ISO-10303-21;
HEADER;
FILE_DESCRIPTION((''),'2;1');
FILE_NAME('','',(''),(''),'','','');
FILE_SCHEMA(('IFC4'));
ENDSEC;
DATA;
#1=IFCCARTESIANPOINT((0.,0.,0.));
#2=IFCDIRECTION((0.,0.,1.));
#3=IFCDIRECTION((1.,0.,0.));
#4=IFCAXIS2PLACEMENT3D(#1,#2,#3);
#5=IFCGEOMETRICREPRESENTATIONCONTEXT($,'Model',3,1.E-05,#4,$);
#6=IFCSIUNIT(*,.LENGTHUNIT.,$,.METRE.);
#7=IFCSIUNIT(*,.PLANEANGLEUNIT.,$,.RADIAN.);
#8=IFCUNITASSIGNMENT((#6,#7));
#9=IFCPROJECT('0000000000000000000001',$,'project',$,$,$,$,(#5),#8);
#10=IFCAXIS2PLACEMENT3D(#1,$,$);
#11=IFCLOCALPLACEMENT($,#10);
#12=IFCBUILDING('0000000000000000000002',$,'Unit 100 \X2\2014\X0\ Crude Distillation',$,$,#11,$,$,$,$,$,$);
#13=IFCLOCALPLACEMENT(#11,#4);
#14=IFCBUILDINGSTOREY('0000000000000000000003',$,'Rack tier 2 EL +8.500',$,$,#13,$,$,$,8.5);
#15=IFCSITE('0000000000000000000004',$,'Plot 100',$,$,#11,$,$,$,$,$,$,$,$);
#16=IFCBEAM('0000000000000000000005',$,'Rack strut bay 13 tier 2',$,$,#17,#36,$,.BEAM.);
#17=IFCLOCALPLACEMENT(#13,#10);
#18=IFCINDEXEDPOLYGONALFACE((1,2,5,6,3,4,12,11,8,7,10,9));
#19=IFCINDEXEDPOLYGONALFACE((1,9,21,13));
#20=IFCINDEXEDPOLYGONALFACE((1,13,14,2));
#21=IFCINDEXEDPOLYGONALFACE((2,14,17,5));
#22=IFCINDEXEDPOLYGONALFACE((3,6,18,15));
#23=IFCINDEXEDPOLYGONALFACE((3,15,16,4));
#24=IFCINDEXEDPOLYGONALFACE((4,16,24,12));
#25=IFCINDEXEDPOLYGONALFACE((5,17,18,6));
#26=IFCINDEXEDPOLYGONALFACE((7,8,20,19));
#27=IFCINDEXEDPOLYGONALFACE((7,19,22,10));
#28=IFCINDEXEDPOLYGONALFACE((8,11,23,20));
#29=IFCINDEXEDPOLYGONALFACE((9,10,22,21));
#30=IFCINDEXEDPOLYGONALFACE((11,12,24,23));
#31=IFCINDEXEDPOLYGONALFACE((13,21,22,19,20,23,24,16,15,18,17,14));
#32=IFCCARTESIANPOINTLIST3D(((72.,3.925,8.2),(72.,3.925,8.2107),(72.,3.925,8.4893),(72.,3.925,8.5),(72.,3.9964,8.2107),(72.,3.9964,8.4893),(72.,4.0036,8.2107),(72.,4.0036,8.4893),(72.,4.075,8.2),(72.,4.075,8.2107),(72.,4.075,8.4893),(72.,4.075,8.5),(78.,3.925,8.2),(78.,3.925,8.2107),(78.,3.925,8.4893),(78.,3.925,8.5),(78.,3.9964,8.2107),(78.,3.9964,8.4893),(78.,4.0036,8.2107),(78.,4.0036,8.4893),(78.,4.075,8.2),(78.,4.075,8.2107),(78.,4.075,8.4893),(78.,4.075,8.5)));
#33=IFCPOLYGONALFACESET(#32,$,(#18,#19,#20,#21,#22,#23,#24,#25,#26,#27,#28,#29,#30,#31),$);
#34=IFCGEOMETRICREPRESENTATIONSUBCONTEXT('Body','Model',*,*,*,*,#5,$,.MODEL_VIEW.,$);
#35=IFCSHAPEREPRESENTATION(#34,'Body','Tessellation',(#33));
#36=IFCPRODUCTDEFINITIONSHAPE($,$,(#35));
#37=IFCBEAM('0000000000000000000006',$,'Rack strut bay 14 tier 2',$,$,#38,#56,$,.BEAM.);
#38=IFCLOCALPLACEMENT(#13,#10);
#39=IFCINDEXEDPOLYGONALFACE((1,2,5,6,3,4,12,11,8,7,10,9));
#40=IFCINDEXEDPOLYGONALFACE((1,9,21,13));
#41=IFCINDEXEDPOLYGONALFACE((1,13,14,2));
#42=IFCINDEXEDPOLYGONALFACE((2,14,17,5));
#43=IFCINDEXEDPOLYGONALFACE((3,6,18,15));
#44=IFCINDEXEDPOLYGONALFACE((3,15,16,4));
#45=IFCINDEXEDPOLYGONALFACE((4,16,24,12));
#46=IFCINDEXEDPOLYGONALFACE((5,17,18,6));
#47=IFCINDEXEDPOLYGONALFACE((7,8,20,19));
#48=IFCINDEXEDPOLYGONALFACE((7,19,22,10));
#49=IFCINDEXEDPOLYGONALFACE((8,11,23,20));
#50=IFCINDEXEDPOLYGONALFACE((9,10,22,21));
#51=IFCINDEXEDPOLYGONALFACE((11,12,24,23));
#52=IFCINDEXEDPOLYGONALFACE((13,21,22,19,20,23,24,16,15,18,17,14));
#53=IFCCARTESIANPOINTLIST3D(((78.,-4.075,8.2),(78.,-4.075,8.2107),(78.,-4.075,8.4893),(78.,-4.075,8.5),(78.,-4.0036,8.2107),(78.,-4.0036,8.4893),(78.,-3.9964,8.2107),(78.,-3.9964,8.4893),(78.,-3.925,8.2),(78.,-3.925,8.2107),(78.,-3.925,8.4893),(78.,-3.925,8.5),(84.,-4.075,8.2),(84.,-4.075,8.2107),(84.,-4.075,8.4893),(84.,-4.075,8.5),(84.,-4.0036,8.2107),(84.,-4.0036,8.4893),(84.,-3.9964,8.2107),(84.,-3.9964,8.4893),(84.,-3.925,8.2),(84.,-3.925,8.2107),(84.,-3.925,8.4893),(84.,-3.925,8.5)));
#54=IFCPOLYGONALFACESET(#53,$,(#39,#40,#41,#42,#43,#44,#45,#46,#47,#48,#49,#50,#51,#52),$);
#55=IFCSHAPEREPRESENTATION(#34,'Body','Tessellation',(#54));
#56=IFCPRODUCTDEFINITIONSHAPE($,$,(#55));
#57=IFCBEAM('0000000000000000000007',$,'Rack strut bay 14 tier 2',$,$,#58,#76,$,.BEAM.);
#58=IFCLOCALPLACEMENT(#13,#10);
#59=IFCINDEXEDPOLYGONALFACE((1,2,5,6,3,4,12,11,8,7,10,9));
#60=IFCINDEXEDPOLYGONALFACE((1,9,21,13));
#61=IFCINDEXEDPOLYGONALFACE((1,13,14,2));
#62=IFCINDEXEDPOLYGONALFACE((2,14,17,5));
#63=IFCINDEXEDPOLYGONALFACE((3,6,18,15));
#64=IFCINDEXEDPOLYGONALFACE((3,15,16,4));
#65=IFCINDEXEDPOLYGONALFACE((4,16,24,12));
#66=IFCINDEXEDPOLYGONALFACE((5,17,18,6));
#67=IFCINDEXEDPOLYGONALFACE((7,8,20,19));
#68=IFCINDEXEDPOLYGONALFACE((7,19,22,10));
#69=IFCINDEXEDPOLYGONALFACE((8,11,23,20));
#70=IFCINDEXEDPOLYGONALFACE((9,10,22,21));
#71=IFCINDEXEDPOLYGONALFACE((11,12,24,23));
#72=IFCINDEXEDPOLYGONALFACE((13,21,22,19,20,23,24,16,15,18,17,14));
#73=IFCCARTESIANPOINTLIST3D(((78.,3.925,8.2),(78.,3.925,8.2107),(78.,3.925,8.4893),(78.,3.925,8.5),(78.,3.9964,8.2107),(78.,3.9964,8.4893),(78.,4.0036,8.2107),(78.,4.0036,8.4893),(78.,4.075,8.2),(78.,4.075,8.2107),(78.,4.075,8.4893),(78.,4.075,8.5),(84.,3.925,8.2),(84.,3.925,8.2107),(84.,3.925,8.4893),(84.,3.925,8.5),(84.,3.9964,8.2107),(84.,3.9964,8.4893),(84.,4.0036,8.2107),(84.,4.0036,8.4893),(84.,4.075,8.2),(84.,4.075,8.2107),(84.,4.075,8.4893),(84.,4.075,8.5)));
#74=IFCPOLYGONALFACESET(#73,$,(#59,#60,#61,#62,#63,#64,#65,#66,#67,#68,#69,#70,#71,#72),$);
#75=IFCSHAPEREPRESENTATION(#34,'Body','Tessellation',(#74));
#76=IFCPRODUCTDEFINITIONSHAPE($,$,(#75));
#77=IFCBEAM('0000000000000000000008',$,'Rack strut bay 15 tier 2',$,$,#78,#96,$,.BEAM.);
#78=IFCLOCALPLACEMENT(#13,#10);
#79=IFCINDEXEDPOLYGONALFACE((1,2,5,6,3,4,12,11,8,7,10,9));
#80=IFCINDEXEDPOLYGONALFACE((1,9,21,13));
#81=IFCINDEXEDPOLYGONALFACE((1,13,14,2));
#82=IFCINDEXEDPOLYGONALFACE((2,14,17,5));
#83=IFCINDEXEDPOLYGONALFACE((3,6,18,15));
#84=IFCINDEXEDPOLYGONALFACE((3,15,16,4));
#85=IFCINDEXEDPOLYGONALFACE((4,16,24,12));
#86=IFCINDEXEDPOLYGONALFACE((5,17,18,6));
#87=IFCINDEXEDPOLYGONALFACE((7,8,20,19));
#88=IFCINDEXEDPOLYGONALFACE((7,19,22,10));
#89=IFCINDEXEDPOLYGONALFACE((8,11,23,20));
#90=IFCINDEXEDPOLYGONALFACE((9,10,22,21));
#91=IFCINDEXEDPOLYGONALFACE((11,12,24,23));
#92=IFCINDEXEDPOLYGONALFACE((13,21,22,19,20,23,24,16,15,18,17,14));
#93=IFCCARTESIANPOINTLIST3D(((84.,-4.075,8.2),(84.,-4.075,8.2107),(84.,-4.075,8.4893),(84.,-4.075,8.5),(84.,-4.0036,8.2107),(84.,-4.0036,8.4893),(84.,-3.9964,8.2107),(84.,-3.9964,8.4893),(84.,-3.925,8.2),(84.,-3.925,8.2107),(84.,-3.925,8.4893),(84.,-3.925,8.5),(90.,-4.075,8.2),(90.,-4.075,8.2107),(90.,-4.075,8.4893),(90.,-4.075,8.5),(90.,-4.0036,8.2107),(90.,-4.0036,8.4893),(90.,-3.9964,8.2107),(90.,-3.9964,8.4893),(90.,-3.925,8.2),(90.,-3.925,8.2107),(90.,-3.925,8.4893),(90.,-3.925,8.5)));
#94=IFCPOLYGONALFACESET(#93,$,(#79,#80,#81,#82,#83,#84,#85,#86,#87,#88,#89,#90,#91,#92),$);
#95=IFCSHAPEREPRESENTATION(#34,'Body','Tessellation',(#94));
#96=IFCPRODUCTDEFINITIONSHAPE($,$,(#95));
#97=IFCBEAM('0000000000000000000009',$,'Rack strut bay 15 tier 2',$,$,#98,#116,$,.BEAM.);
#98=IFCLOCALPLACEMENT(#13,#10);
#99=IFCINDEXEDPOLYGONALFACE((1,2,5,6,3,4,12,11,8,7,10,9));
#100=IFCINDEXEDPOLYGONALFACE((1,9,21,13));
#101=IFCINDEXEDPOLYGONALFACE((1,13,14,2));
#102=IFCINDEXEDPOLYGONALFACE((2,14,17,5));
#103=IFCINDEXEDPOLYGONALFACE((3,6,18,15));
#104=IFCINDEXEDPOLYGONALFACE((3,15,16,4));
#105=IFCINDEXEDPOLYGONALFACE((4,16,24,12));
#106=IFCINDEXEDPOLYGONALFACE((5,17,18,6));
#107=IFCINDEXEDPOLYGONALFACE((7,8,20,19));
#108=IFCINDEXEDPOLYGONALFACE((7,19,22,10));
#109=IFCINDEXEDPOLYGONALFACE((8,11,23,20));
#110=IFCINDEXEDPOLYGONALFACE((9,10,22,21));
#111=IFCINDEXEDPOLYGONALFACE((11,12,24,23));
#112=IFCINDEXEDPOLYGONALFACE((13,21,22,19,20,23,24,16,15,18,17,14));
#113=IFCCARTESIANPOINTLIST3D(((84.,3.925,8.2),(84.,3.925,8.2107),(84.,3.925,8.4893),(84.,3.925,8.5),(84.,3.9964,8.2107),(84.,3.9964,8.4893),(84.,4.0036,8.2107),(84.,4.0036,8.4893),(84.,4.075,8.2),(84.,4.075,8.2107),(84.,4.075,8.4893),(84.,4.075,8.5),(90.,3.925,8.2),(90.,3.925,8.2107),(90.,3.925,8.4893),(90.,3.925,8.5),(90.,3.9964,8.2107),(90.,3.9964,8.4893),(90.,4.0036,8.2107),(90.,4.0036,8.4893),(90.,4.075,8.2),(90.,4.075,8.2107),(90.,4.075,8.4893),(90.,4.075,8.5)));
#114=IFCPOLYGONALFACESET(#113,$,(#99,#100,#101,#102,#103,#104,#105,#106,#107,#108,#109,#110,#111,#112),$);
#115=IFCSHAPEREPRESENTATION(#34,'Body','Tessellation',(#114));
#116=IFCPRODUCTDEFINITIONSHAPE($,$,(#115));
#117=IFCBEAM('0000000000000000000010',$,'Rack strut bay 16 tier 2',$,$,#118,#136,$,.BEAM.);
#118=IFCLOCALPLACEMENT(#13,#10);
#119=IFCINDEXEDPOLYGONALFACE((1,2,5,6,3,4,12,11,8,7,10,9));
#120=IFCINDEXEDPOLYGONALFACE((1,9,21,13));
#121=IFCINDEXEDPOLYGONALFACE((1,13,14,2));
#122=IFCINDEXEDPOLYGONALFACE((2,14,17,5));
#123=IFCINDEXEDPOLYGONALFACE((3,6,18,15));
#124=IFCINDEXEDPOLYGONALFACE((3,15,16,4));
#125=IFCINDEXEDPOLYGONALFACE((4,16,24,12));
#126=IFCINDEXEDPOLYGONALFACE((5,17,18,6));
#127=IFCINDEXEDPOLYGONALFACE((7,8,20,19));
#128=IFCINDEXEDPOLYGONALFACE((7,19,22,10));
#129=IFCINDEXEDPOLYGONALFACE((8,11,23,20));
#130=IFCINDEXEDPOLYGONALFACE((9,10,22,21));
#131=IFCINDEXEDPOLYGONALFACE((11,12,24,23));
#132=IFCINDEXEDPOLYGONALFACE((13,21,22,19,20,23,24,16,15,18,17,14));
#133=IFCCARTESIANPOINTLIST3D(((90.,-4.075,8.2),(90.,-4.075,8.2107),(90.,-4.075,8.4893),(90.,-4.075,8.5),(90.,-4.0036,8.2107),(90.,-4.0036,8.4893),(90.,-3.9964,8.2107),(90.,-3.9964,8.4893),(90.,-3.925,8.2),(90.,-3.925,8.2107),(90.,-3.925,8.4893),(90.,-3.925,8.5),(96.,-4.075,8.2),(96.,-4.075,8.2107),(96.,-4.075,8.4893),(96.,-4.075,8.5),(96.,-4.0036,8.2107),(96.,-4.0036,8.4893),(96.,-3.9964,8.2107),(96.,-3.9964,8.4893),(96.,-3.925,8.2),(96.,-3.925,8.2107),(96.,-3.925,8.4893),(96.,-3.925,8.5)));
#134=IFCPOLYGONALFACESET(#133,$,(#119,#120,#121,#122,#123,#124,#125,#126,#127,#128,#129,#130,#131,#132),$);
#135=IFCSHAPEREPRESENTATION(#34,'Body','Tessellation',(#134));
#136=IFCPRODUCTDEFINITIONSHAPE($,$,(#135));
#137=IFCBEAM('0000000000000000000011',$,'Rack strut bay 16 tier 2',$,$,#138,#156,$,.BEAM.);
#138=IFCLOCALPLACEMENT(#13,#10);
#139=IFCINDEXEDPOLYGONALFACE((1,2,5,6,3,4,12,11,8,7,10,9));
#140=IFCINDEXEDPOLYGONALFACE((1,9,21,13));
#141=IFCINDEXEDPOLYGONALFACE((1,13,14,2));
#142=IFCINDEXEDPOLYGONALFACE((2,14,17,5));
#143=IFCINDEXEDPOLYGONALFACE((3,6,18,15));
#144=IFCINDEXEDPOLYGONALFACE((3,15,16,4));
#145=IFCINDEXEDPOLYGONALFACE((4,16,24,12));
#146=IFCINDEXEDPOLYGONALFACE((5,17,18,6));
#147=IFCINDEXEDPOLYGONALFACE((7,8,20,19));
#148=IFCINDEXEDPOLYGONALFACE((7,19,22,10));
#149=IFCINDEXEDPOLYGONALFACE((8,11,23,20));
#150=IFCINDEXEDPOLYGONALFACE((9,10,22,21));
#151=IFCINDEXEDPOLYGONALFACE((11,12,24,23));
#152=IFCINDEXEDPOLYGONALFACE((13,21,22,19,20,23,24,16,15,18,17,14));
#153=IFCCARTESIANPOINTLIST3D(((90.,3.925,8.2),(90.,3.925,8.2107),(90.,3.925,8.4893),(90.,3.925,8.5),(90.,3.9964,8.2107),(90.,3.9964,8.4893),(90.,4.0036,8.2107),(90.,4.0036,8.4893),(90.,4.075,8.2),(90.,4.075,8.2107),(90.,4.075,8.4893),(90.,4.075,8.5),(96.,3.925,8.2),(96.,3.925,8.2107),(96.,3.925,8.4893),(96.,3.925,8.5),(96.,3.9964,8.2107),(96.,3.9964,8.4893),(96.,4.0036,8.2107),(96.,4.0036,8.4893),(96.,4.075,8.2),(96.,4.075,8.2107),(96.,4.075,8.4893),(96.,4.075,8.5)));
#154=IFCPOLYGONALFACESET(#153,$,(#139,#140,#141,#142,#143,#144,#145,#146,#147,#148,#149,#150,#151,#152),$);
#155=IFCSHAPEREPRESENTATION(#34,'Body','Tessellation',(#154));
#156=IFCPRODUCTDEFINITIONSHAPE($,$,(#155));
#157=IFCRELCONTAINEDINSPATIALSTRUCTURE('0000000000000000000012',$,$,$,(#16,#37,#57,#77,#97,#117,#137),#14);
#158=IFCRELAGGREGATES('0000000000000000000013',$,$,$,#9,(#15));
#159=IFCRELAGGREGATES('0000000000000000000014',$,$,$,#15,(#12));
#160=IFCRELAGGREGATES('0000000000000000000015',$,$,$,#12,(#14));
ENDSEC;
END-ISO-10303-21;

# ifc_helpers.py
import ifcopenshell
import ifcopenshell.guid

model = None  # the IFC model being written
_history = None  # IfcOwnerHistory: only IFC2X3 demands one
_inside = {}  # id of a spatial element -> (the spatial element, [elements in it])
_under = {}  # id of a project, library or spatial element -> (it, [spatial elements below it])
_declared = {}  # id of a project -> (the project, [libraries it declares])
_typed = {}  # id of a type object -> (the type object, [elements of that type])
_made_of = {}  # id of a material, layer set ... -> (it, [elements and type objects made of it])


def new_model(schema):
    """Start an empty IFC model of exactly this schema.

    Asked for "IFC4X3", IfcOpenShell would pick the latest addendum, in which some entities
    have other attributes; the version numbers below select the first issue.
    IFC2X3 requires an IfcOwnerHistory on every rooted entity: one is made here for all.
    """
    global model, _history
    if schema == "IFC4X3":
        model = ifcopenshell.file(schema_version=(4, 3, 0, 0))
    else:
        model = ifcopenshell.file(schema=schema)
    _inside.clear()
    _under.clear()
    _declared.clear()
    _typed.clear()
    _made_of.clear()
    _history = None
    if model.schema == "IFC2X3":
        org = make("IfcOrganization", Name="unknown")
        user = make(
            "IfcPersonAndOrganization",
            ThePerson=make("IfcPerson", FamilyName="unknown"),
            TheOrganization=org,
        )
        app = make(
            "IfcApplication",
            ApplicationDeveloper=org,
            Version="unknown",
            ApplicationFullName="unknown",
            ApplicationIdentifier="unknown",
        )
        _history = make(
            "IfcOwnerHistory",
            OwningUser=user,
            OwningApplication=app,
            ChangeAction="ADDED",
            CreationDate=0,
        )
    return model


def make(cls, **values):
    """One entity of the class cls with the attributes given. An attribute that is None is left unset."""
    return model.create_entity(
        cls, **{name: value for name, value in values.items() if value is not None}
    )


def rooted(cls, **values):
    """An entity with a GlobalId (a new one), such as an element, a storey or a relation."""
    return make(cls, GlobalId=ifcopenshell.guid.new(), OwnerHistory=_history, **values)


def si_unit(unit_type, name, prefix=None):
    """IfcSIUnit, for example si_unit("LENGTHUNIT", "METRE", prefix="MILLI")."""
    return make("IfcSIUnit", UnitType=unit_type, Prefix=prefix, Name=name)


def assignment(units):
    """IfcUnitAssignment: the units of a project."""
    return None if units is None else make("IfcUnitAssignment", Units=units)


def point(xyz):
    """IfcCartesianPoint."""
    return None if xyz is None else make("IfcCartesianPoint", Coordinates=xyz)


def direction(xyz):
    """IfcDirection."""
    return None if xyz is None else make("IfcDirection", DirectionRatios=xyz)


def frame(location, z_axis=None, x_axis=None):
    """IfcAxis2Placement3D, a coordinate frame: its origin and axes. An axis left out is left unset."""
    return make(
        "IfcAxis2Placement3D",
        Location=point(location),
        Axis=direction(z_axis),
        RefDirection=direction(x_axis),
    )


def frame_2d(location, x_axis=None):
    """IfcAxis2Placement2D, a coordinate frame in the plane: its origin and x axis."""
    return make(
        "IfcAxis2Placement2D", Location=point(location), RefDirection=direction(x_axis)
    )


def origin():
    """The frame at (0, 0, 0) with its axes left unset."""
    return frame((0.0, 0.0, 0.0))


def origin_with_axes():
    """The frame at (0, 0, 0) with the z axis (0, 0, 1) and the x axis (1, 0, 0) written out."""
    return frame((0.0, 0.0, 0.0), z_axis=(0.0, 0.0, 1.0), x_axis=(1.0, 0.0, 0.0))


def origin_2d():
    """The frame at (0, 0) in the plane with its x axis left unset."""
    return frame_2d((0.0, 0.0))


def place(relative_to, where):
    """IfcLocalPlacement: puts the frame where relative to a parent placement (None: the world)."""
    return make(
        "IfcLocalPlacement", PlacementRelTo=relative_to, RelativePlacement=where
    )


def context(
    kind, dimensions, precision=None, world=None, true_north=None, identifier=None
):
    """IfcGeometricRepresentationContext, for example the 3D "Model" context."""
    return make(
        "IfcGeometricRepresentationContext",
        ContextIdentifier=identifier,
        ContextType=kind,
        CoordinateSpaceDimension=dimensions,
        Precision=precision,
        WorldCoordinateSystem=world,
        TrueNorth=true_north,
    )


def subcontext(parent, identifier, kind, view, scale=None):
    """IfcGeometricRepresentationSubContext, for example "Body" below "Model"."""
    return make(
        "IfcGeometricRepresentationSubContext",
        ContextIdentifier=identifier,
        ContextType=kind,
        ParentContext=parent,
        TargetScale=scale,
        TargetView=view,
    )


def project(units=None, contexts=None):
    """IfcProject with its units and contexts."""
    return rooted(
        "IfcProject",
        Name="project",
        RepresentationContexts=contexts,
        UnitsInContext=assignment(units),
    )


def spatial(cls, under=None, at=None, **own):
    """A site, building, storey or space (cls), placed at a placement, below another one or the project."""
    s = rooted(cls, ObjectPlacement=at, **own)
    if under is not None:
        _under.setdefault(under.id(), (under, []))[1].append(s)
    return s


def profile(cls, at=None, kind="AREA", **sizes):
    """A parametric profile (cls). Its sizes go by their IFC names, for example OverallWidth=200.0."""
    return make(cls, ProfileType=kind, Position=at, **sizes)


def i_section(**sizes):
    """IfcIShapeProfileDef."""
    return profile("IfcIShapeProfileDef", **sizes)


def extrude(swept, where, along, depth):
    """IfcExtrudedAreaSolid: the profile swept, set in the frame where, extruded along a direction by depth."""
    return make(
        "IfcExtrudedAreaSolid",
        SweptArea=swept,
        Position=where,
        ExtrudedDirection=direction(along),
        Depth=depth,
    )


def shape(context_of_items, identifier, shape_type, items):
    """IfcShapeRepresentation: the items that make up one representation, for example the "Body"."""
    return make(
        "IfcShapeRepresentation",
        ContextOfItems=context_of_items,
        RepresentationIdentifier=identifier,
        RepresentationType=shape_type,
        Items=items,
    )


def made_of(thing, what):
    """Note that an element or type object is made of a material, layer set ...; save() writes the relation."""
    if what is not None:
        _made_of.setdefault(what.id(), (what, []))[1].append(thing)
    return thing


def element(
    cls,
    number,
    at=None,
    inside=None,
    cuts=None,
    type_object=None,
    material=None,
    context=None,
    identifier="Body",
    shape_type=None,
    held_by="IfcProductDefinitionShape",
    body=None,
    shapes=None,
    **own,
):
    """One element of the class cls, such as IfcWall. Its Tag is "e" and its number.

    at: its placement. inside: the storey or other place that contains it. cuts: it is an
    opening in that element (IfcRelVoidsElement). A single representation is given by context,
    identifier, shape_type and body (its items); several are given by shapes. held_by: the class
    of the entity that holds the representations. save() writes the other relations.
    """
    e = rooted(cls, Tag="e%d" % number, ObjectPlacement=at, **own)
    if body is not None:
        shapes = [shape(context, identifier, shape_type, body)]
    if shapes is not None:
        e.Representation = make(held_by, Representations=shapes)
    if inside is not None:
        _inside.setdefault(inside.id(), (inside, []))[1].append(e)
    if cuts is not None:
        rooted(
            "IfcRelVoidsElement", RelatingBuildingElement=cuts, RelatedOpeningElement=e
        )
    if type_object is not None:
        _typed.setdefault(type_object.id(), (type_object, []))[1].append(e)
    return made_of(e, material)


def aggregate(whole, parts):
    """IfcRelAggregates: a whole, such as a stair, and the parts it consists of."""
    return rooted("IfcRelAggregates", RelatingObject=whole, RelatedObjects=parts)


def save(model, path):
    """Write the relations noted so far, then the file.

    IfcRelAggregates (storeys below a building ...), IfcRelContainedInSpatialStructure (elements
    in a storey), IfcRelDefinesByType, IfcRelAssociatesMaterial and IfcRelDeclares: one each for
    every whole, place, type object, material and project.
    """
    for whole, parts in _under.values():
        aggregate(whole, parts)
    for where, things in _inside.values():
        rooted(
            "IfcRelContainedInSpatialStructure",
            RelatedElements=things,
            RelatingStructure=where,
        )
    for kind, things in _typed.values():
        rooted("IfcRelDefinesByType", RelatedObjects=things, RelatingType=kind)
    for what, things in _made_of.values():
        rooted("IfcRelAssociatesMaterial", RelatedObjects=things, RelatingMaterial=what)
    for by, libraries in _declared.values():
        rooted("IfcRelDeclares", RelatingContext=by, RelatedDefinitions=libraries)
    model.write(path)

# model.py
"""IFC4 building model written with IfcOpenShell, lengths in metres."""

from ifc_helpers import new_model, si_unit, frame, origin, origin_with_axes, origin_2d, place, context, subcontext, project, spatial, i_section, extrude, element, save


model = new_model("IFC4")

# Units and contexts
model_context = context("Model", 3, precision=1e-05, world=origin_with_axes())
body_context = subcontext(model_context, "Body", "Model", "MODEL_VIEW")
ifc_project = project(units=[si_unit("LENGTHUNIT", "METRE"), si_unit("PLANEANGLEUNIT", "RADIAN")], contexts=[model_context])

# Site, building, storey
placement = place(None, origin())
site = spatial("IfcSite", under=ifc_project, at=placement, Name="Plot 100")
building = spatial("IfcBuilding", under=site, at=placement, Name="Unit 100 — Crude Distillation")
storey_placement = place(placement, origin_with_axes())
storey = spatial("IfcBuildingStorey", under=building, at=storey_placement, Name="Rack tier 2 EL +8.500", Elevation=8.5)

# Beams
beam_1_placement = place(storey_placement, origin_with_axes())
element("IfcBeam", 1, at=beam_1_placement, inside=storey, Name="Rack strut bay 13 tier 2", PredefinedType="BEAM", context=body_context, shape_type="SweptSolid", body=[
    extrude(i_section(OverallWidth=0.15, OverallDepth=0.3, WebThickness=0.0071, FlangeThickness=0.0107, at=origin_2d()), frame((72.0, 4.0, 8.35), z_axis=(1.0, 0.0, 0.0), x_axis=(0.0, 1.0, 0.0)), (0.0, 0.0, 1.0), 6.0),
])
beam_2_placement = place(storey_placement, origin_with_axes())
element("IfcBeam", 2, at=beam_2_placement, inside=storey, Name="Rack strut bay 14 tier 2", PredefinedType="BEAM", context=body_context, shape_type="SweptSolid", body=[
    extrude(i_section(OverallWidth=0.15, OverallDepth=0.3, WebThickness=0.0071, FlangeThickness=0.0107, at=origin_2d()), frame((78.0, -4.0, 8.35), z_axis=(1.0, 0.0, 0.0), x_axis=(0.0, 1.0, 0.0)), (0.0, 0.0, 1.0), 6.0),
])
beam_3_placement = place(storey_placement, origin_with_axes())
element("IfcBeam", 3, at=beam_3_placement, inside=storey, Name="Rack strut bay 14 tier 2", PredefinedType="BEAM", context=body_context, shape_type="SweptSolid", body=[
    extrude(i_section(OverallWidth=0.15, OverallDepth=0.3, WebThickness=0.0071, FlangeThickness=0.0107, at=origin_2d()), frame((78.0, 4.0, 8.35), z_axis=(1.0, 0.0, 0.0), x_axis=(0.0, 1.0, 0.0)), (0.0, 0.0, 1.0), 6.0),
])
beam_4_placement = place(storey_placement, origin_with_axes())
element("IfcBeam", 4, at=beam_4_placement, inside=storey, Name="Rack strut bay 15 tier 2", PredefinedType="BEAM", context=body_context, shape_type="SweptSolid", body=[
    extrude(i_section(OverallWidth=0.15, OverallDepth=0.3, WebThickness=0.0071, FlangeThickness=0.0107, at=origin_2d()), frame((84.0, -4.0, 8.35), z_axis=(1.0, 0.0, 0.0), x_axis=(0.0, 1.0, 0.0)), (0.0, 0.0, 1.0), 6.0),
])
beam_5_placement = place(storey_placement, origin_with_axes())
element("IfcBeam", 5, at=beam_5_placement, inside=storey, Name="Rack strut bay 15 tier 2", PredefinedType="BEAM", context=body_context, shape_type="SweptSolid", body=[
    extrude(i_section(OverallWidth=0.15, OverallDepth=0.3, WebThickness=0.0071, FlangeThickness=0.0107, at=origin_2d()), frame((84.0, 4.0, 8.35), z_axis=(1.0, 0.0, 0.0), x_axis=(0.0, 1.0, 0.0)), (0.0, 0.0, 1.0), 6.0),
])
beam_6_placement = place(storey_placement, origin_with_axes())
element("IfcBeam", 6, at=beam_6_placement, inside=storey, Name="Rack strut bay 16 tier 2", PredefinedType="BEAM", context=body_context, shape_type="SweptSolid", body=[
    extrude(i_section(OverallWidth=0.15, OverallDepth=0.3, WebThickness=0.0071, FlangeThickness=0.0107, at=origin_2d()), frame((90.0, -4.0, 8.35), z_axis=(1.0, 0.0, 0.0), x_axis=(0.0, 1.0, 0.0)), (0.0, 0.0, 1.0), 6.0),
])
beam_7_placement = place(storey_placement, origin_with_axes())
element("IfcBeam", 7, at=beam_7_placement, inside=storey, Name="Rack strut bay 16 tier 2", PredefinedType="BEAM", context=body_context, shape_type="SweptSolid", body=[
    extrude(i_section(OverallWidth=0.15, OverallDepth=0.3, WebThickness=0.0071, FlangeThickness=0.0107, at=origin_2d()), frame((90.0, 4.0, 8.35), z_axis=(1.0, 0.0, 0.0), x_axis=(0.0, 1.0, 0.0)), (0.0, 0.0, 1.0), 6.0),
])

save(model, "model.ifc")
